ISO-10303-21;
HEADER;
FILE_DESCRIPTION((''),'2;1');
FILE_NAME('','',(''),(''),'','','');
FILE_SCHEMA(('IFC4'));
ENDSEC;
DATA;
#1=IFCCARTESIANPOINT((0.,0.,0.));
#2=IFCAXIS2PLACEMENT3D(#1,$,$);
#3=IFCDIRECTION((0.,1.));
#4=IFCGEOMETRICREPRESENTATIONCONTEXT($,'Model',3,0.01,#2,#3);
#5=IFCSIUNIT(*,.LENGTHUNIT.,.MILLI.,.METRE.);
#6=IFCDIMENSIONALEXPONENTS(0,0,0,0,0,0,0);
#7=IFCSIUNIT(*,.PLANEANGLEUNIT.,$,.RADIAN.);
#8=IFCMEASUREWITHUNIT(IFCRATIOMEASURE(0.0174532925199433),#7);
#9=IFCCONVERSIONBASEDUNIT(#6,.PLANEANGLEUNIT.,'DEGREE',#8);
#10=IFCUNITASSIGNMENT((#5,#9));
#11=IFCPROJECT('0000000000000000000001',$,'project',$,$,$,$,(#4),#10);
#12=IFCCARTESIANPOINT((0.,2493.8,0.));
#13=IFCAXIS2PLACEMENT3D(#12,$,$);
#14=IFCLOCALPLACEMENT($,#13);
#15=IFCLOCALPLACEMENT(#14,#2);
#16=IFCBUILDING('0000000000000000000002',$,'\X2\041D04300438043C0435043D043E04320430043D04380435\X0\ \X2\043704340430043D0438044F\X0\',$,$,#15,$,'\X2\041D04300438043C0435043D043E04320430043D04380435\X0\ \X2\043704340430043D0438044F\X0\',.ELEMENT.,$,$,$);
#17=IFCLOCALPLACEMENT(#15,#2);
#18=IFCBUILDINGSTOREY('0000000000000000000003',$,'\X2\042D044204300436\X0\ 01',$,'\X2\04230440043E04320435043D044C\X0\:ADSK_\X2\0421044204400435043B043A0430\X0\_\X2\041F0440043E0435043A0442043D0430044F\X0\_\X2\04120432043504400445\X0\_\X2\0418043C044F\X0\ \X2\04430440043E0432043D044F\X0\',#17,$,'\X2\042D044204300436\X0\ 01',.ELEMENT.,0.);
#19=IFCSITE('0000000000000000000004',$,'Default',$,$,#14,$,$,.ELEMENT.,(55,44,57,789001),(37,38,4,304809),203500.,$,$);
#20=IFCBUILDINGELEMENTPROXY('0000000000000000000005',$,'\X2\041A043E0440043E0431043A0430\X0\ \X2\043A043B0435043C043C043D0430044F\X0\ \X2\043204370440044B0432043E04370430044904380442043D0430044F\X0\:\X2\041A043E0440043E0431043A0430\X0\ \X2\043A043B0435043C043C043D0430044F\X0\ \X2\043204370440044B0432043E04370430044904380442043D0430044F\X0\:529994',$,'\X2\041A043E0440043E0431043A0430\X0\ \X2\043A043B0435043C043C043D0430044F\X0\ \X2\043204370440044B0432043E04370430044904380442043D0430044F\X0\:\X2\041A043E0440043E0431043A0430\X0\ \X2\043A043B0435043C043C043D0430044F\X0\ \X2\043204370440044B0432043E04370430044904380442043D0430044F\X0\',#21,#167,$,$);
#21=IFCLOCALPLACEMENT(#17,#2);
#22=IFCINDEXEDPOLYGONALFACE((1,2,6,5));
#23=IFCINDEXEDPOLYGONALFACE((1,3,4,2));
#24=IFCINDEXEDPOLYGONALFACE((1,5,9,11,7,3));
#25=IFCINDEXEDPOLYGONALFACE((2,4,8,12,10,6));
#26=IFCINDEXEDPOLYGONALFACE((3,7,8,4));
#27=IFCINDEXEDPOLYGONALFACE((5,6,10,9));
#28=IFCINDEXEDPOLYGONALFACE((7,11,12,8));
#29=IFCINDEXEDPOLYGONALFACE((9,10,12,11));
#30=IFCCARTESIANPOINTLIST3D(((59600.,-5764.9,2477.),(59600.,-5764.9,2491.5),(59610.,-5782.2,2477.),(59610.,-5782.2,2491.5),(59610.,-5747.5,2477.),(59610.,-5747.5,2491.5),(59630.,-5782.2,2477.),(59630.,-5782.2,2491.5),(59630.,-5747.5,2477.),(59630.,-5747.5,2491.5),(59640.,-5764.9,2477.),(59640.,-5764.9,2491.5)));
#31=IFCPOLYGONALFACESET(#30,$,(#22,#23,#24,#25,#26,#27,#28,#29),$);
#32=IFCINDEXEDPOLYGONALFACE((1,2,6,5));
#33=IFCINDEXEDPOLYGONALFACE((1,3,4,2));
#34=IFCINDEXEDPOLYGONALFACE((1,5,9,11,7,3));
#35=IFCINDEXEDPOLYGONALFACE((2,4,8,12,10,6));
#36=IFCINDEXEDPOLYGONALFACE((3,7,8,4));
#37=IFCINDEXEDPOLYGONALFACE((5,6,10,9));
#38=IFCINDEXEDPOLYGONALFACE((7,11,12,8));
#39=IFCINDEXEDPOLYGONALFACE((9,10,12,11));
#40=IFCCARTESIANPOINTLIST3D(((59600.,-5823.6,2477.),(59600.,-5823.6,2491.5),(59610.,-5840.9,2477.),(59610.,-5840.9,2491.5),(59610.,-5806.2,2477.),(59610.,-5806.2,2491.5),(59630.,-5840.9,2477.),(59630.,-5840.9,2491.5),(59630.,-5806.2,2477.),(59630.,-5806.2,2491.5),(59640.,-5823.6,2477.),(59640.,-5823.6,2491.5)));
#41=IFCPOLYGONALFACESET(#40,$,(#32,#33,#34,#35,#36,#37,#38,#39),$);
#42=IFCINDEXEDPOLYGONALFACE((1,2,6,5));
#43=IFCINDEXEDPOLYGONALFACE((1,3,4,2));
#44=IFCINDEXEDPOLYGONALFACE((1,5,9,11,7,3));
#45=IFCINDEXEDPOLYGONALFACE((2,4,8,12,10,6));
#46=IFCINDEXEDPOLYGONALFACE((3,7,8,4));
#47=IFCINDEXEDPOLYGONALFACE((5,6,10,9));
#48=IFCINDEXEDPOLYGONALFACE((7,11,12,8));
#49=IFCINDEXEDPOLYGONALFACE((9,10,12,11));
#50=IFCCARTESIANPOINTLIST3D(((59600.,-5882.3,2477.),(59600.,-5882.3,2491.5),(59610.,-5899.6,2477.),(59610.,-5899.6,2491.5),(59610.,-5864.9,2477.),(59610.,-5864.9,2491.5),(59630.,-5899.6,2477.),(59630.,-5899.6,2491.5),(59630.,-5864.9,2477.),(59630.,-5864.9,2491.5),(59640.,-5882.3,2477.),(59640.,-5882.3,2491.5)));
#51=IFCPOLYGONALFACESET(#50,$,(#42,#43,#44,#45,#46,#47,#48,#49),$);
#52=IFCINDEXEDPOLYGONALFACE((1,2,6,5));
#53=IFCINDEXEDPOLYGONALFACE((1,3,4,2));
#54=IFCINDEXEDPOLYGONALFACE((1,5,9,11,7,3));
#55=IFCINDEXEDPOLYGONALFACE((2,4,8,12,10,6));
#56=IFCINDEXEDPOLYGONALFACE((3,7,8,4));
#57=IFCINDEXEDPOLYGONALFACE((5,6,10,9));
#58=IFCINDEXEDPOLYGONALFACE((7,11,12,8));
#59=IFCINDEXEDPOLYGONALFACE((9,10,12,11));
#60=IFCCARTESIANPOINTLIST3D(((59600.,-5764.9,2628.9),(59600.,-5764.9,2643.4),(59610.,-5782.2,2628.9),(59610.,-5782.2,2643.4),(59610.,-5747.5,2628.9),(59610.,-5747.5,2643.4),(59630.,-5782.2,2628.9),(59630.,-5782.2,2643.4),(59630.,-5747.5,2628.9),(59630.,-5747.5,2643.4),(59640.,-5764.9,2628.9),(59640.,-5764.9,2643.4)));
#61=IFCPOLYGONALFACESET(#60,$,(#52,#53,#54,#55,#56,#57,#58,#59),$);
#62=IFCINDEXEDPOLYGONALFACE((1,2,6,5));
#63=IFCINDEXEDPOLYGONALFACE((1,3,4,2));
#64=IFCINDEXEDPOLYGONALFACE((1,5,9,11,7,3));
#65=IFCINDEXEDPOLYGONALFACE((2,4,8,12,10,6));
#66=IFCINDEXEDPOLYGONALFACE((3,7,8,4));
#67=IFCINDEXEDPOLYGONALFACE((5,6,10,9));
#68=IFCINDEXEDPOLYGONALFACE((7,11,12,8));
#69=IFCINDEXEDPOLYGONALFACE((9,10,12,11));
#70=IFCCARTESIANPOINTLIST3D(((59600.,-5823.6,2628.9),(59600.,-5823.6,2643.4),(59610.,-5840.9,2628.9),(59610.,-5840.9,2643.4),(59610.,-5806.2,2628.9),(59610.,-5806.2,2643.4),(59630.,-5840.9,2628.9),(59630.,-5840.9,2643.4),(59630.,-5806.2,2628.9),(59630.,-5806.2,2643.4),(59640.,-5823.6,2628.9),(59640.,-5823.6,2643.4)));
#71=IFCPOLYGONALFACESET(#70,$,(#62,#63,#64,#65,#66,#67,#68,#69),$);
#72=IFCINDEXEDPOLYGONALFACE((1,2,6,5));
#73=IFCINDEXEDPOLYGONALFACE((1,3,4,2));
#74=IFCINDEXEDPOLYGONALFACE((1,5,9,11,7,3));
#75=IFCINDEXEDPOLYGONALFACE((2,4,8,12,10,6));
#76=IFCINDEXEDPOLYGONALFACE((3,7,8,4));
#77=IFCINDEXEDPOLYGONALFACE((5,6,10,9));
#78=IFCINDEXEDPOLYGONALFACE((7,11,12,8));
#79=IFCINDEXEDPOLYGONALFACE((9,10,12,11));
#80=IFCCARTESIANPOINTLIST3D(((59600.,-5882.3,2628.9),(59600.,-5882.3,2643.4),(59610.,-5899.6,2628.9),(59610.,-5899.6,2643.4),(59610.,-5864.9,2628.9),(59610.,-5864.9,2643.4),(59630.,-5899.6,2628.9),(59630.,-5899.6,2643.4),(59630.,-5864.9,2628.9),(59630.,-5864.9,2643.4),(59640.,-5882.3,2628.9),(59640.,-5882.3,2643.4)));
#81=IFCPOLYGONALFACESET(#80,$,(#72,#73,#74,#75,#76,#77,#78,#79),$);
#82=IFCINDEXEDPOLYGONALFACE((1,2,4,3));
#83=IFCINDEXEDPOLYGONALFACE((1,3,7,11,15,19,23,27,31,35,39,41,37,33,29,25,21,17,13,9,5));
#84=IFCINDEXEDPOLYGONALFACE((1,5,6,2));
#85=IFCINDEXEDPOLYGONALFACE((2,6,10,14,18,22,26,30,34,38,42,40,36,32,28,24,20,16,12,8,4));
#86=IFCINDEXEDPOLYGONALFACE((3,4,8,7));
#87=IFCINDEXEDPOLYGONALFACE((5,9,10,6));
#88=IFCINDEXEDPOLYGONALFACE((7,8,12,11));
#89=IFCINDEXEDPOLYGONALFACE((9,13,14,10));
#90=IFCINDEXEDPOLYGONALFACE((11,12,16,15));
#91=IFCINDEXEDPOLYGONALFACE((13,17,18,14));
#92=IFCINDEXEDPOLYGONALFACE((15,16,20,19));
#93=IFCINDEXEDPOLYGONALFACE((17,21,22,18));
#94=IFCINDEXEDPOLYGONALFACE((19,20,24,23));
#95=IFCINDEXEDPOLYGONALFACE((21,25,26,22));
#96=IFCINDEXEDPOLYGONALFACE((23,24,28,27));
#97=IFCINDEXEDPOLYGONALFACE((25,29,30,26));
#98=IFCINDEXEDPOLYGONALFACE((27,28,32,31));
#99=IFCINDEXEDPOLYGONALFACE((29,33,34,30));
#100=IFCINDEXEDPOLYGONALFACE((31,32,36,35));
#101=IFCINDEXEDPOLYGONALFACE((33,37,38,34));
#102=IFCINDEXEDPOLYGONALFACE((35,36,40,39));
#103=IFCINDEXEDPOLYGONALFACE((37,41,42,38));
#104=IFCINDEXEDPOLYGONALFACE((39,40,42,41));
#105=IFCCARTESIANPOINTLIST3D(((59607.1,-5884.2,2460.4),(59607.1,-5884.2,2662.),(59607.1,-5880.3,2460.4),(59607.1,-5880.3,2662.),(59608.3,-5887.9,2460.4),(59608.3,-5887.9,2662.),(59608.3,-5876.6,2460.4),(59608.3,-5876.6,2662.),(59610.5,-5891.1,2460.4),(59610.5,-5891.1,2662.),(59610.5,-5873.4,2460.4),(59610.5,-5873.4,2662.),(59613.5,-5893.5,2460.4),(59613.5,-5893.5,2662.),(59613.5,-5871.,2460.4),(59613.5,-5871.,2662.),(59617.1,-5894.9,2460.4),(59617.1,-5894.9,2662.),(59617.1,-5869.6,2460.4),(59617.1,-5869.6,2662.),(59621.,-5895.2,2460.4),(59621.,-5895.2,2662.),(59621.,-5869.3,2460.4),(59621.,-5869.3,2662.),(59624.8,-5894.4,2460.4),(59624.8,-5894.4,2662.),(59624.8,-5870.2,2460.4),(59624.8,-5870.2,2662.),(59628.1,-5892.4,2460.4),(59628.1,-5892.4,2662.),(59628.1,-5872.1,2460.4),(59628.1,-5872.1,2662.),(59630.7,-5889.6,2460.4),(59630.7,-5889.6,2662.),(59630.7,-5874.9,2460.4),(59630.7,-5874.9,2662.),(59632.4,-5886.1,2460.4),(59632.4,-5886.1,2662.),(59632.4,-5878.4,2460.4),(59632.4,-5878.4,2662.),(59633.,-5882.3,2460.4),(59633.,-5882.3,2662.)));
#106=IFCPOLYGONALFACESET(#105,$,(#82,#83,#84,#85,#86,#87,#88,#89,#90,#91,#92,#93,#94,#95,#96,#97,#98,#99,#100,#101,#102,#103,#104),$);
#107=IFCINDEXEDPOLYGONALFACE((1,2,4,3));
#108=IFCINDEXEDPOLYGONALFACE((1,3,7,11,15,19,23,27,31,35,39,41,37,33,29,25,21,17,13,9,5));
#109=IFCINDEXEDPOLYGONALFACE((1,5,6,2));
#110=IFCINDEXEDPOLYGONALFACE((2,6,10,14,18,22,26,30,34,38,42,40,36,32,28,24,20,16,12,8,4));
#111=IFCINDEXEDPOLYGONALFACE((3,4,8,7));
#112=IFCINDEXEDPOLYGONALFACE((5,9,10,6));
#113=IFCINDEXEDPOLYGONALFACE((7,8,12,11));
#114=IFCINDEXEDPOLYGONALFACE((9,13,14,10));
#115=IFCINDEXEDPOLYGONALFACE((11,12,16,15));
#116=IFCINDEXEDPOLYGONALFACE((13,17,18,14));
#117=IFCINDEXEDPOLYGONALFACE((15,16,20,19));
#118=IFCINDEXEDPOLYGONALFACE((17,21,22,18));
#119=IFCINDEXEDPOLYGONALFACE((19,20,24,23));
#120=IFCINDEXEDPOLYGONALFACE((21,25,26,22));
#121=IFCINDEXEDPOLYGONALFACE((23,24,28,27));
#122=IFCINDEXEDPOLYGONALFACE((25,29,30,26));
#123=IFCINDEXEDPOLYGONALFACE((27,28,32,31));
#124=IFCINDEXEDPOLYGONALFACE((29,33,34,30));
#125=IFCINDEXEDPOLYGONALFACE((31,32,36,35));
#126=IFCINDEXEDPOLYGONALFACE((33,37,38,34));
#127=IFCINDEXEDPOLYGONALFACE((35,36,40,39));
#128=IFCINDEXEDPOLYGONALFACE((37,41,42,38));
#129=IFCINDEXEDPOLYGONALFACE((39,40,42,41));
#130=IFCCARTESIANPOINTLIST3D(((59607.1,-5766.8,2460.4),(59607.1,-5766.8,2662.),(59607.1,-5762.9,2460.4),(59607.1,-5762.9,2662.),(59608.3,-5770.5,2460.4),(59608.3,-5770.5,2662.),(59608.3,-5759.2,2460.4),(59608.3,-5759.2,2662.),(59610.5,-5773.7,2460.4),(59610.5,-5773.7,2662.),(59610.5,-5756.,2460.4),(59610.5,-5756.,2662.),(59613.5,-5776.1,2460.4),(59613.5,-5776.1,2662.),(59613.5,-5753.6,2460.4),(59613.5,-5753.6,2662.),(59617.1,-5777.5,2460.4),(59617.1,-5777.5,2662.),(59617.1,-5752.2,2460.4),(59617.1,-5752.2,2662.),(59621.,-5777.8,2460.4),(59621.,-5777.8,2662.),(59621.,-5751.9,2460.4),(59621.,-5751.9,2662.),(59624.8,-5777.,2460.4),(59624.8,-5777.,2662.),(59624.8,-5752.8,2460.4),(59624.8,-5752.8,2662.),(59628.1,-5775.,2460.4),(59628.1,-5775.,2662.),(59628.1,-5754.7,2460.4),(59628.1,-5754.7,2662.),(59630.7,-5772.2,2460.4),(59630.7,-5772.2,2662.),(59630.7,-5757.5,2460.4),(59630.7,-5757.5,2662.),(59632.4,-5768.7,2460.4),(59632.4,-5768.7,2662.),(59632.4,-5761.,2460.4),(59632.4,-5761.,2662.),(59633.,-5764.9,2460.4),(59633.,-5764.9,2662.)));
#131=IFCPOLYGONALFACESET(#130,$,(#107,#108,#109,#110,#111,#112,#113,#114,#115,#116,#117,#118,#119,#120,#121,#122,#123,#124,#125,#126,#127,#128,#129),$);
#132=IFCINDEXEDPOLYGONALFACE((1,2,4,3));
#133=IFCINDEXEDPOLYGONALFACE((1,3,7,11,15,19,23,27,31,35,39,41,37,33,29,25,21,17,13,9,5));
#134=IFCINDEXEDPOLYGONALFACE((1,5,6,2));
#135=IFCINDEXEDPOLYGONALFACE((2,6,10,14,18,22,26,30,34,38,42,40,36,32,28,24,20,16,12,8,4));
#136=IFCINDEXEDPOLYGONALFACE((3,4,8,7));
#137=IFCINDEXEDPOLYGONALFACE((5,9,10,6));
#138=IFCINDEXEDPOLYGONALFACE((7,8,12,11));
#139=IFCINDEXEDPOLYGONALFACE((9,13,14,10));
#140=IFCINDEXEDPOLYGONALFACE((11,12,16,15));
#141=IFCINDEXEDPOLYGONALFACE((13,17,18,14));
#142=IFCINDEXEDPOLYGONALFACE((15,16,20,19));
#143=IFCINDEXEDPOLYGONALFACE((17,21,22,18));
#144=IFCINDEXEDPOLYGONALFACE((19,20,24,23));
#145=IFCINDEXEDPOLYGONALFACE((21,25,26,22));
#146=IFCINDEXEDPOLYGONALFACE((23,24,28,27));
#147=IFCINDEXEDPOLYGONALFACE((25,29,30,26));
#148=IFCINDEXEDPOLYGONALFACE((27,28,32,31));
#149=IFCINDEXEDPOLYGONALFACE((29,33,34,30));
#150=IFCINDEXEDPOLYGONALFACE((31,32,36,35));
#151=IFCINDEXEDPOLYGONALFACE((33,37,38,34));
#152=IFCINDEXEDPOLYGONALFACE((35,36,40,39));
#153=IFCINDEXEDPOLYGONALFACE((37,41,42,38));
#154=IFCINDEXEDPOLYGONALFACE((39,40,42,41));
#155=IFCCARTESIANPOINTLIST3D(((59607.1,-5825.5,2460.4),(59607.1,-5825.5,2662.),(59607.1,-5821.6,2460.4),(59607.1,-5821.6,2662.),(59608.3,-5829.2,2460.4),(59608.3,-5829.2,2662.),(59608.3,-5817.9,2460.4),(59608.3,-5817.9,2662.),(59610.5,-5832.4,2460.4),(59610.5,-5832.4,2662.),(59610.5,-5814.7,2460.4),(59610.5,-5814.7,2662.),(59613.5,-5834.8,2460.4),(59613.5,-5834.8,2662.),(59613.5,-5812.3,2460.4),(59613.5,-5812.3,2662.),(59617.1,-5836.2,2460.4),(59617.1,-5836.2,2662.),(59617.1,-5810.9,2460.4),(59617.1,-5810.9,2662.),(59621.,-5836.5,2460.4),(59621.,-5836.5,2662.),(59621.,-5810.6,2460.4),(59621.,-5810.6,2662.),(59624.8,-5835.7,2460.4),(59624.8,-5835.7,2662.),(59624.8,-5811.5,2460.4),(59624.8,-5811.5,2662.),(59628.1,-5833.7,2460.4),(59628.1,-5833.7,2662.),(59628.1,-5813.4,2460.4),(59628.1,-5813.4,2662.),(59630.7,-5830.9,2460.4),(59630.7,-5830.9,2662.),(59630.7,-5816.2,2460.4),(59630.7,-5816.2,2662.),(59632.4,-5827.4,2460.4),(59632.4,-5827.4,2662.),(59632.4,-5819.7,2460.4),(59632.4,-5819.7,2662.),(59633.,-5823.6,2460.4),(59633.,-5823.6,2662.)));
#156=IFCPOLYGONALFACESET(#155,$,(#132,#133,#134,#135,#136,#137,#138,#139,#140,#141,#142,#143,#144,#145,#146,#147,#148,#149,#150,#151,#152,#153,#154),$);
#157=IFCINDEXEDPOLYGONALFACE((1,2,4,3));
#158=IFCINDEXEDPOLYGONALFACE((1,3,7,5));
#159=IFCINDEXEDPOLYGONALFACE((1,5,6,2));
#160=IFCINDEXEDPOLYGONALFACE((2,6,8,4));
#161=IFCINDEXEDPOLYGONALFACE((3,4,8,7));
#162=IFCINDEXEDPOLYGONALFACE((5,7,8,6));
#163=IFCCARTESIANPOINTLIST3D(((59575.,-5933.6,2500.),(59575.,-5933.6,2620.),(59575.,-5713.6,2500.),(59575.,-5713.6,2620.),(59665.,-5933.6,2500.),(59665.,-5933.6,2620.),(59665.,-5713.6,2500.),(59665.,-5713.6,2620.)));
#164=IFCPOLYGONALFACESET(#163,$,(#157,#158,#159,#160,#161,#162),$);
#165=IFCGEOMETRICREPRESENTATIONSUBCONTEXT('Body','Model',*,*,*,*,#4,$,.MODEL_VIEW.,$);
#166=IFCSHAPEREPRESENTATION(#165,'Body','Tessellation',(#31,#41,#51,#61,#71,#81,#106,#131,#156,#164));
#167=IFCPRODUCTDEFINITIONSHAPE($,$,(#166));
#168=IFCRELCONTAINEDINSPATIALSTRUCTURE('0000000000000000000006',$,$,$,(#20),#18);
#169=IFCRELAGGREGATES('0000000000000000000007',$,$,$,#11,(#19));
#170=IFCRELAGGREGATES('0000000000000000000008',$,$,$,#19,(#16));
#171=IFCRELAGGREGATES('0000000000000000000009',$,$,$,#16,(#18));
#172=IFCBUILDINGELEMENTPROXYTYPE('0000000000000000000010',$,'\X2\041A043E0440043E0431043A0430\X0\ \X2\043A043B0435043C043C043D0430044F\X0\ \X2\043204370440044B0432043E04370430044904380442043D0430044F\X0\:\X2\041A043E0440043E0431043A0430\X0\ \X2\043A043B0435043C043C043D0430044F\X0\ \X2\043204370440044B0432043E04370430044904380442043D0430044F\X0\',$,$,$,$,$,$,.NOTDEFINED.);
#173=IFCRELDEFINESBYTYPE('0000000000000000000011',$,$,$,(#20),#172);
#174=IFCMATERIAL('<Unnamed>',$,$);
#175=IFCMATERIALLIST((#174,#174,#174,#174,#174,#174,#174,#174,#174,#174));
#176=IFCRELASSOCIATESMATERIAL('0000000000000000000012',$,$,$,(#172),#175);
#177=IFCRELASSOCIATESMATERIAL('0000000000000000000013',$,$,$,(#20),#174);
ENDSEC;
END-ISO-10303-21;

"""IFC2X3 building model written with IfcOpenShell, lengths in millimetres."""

from ifc_helpers import new_model, entity, si_unit, converted_unit, direction, frame, frame_2d, origin, place, context, subcontext, project, spatial, polyline, rectangle, circle, outline, extrude, source, transform, mapped, material, material_list, type_object, type_shapes, element, save


model = new_model("IFC2X3")

# Units and contexts
model_context = context("Model", 3, precision=0.01, world=origin(), true_north=direction((0.0, 1.0)))
body_context = subcontext(model_context, "Body", "Model", "MODEL_VIEW")
ifc_project = project(units=[si_unit("LENGTHUNIT", "METRE", prefix="MILLI"), converted_unit("PLANEANGLEUNIT", "DEGREE", entity("IfcRatioMeasure", 0.0174532925199433), si_unit("PLANEANGLEUNIT", "RADIAN"), dimensions=[0, 0, 0, 0, 0, 0, 0])], contexts=[model_context])

# Site, building, storey
site_placement = place(None, frame((0.0, 2493.8, 0.0)))
site = spatial("IfcSite", under=ifc_project, at=site_placement, Name="Default", CompositionType="ELEMENT", RefLatitude=(55, 44, 57, 789001), RefLongitude=(37, 38, 4, 304809), RefElevation=203500.0)
building_placement = place(site_placement, origin())
building = spatial("IfcBuilding", under=site, at=building_placement, Name="Наименование здания", LongName="Наименование здания", CompositionType="ELEMENT")
storey_placement = place(building_placement, origin())
storey = spatial("IfcBuildingStorey", under=building, at=storey_placement, Name="Этаж 01", ObjectType="Уровень:ADSK_Стрелка_Проектная_Вверх_Имя уровня", LongName="Этаж 01", CompositionType="ELEMENT", Elevation=0.0)

# Building element proxy
ifc_material_1 = material(Name="<Unnamed>")
ifc_material_list_1 = material_list([ifc_material_1, ifc_material_1, ifc_material_1, ifc_material_1, ifc_material_1, ifc_material_1, ifc_material_1, ifc_material_1, ifc_material_1, ifc_material_1])
building_element_proxy_type_1 = type_object("IfcBuildingElementProxyType", Name="Коробка клеммная взрывозащитная:Коробка клеммная взрывозащитная", PredefinedType="NOTDEFINED", material=ifc_material_list_1)
shared_shape_1 = source(origin(), body_context, "Body", "SweptSolid", [
    extrude(outline(polyline([(-10.0, -17.3), (10.0, -17.3), (20.0, 0.0), (10.0, 17.3), (-10.0, 17.3), (-20.0, 0.0), (-10.0, -17.3)])), frame((0.0, 58.7, -23.0), z_axis=(0.0, 0.0, 1.0), x_axis=(-1.0, 0.0, 0.0)), (0.0, 0.0, 1.0), 14.4),
    extrude(outline(polyline([(-10.0, -17.3), (10.0, -17.3), (20.0, 0.0), (10.0, 17.3), (-10.0, 17.3), (-20.0, 0.0), (-10.0, -17.3)])), frame((0.0, 0.0, -23.0), z_axis=(0.0, 0.0, 1.0), x_axis=(-1.0, 0.0, 0.0)), (0.0, 0.0, 1.0), 14.4),
    extrude(outline(polyline([(-10.0, -17.3), (10.0, -17.3), (20.0, 0.0), (10.0, 17.3), (-10.0, 17.3), (-20.0, 0.0), (-10.0, -17.3)])), frame((0.0, -58.7, -23.0), z_axis=(0.0, 0.0, 1.0), x_axis=(-1.0, 0.0, 0.0)), (0.0, 0.0, 1.0), 14.4),
    extrude(outline(polyline([(-10.0, -17.3), (10.0, -17.3), (20.0, 0.0), (10.0, 17.3), (-10.0, 17.3), (-20.0, 0.0), (-10.0, -17.3)])), frame((0.0, 58.7, 128.9), z_axis=(0.0, 0.0, 1.0), x_axis=(-1.0, 0.0, 0.0)), (0.0, 0.0, 1.0), 14.4),
    extrude(outline(polyline([(-10.0, -17.3), (10.0, -17.3), (20.0, 0.0), (10.0, 17.3), (-10.0, 17.3), (-20.0, 0.0), (-10.0, -17.3)])), frame((0.0, 0.0, 128.9), z_axis=(0.0, 0.0, 1.0), x_axis=(-1.0, 0.0, 0.0)), (0.0, 0.0, 1.0), 14.4),
    extrude(outline(polyline([(-10.0, -17.3), (10.0, -17.3), (20.0, 0.0), (10.0, 17.3), (-10.0, 17.3), (-20.0, 0.0), (-10.0, -17.3)])), frame((0.0, -58.7, 128.9), z_axis=(0.0, 0.0, 1.0), x_axis=(-1.0, 0.0, 0.0)), (0.0, 0.0, 1.0), 14.4),
    extrude(circle(Radius=13.0, at=frame_2d((0.0, 0.0), x_axis=(1.0, 0.0))), frame((0.0, -58.7, -39.6)), (0.0, 0.0, 1.0), 201.6),
    extrude(circle(Radius=13.0, at=frame_2d((0.0, 0.0), x_axis=(1.0, 0.0))), frame((0.0, 58.7, -39.6)), (0.0, 0.0, 1.0), 201.6),
    extrude(circle(Radius=13.0, at=frame_2d((0.0, 0.0), x_axis=(1.0, 0.0))), frame((0.0, 0.0, -39.6)), (0.0, 0.0, 1.0), 201.6),
    extrude(rectangle(XDim=220.0, YDim=90.0, at=frame_2d((0.0, 0.0), x_axis=(1.0, 0.0))), frame((0.0, 0.0, 0.0), z_axis=(0.0, 0.0, 1.0), x_axis=(0.0, -1.0, 0.0)), (0.0, 0.0, 1.0), 120.0),
])
type_shapes(building_element_proxy_type_1, [shared_shape_1])
for number, where, name in (
    (1, (59620.0, -5823.6, 2500.0), "Коробка клеммная взрывозащитная:Коробка клеммная взрывозащитная:529994"),
):
    element("IfcBuildingElementProxy", number, at=place(storey_placement, frame(where)), inside=storey, type_object=building_element_proxy_type_1, material=ifc_material_1, Name=name, ObjectType="Коробка клеммная взрывозащитная:Коробка клеммная взрывозащитная", context=body_context, shape_type="MappedRepresentation", body=[
        mapped(shared_shape_1, transform((0.0, 0.0, 0.0), scale=1.0)),
    ])

save(model, "model.ifc")
